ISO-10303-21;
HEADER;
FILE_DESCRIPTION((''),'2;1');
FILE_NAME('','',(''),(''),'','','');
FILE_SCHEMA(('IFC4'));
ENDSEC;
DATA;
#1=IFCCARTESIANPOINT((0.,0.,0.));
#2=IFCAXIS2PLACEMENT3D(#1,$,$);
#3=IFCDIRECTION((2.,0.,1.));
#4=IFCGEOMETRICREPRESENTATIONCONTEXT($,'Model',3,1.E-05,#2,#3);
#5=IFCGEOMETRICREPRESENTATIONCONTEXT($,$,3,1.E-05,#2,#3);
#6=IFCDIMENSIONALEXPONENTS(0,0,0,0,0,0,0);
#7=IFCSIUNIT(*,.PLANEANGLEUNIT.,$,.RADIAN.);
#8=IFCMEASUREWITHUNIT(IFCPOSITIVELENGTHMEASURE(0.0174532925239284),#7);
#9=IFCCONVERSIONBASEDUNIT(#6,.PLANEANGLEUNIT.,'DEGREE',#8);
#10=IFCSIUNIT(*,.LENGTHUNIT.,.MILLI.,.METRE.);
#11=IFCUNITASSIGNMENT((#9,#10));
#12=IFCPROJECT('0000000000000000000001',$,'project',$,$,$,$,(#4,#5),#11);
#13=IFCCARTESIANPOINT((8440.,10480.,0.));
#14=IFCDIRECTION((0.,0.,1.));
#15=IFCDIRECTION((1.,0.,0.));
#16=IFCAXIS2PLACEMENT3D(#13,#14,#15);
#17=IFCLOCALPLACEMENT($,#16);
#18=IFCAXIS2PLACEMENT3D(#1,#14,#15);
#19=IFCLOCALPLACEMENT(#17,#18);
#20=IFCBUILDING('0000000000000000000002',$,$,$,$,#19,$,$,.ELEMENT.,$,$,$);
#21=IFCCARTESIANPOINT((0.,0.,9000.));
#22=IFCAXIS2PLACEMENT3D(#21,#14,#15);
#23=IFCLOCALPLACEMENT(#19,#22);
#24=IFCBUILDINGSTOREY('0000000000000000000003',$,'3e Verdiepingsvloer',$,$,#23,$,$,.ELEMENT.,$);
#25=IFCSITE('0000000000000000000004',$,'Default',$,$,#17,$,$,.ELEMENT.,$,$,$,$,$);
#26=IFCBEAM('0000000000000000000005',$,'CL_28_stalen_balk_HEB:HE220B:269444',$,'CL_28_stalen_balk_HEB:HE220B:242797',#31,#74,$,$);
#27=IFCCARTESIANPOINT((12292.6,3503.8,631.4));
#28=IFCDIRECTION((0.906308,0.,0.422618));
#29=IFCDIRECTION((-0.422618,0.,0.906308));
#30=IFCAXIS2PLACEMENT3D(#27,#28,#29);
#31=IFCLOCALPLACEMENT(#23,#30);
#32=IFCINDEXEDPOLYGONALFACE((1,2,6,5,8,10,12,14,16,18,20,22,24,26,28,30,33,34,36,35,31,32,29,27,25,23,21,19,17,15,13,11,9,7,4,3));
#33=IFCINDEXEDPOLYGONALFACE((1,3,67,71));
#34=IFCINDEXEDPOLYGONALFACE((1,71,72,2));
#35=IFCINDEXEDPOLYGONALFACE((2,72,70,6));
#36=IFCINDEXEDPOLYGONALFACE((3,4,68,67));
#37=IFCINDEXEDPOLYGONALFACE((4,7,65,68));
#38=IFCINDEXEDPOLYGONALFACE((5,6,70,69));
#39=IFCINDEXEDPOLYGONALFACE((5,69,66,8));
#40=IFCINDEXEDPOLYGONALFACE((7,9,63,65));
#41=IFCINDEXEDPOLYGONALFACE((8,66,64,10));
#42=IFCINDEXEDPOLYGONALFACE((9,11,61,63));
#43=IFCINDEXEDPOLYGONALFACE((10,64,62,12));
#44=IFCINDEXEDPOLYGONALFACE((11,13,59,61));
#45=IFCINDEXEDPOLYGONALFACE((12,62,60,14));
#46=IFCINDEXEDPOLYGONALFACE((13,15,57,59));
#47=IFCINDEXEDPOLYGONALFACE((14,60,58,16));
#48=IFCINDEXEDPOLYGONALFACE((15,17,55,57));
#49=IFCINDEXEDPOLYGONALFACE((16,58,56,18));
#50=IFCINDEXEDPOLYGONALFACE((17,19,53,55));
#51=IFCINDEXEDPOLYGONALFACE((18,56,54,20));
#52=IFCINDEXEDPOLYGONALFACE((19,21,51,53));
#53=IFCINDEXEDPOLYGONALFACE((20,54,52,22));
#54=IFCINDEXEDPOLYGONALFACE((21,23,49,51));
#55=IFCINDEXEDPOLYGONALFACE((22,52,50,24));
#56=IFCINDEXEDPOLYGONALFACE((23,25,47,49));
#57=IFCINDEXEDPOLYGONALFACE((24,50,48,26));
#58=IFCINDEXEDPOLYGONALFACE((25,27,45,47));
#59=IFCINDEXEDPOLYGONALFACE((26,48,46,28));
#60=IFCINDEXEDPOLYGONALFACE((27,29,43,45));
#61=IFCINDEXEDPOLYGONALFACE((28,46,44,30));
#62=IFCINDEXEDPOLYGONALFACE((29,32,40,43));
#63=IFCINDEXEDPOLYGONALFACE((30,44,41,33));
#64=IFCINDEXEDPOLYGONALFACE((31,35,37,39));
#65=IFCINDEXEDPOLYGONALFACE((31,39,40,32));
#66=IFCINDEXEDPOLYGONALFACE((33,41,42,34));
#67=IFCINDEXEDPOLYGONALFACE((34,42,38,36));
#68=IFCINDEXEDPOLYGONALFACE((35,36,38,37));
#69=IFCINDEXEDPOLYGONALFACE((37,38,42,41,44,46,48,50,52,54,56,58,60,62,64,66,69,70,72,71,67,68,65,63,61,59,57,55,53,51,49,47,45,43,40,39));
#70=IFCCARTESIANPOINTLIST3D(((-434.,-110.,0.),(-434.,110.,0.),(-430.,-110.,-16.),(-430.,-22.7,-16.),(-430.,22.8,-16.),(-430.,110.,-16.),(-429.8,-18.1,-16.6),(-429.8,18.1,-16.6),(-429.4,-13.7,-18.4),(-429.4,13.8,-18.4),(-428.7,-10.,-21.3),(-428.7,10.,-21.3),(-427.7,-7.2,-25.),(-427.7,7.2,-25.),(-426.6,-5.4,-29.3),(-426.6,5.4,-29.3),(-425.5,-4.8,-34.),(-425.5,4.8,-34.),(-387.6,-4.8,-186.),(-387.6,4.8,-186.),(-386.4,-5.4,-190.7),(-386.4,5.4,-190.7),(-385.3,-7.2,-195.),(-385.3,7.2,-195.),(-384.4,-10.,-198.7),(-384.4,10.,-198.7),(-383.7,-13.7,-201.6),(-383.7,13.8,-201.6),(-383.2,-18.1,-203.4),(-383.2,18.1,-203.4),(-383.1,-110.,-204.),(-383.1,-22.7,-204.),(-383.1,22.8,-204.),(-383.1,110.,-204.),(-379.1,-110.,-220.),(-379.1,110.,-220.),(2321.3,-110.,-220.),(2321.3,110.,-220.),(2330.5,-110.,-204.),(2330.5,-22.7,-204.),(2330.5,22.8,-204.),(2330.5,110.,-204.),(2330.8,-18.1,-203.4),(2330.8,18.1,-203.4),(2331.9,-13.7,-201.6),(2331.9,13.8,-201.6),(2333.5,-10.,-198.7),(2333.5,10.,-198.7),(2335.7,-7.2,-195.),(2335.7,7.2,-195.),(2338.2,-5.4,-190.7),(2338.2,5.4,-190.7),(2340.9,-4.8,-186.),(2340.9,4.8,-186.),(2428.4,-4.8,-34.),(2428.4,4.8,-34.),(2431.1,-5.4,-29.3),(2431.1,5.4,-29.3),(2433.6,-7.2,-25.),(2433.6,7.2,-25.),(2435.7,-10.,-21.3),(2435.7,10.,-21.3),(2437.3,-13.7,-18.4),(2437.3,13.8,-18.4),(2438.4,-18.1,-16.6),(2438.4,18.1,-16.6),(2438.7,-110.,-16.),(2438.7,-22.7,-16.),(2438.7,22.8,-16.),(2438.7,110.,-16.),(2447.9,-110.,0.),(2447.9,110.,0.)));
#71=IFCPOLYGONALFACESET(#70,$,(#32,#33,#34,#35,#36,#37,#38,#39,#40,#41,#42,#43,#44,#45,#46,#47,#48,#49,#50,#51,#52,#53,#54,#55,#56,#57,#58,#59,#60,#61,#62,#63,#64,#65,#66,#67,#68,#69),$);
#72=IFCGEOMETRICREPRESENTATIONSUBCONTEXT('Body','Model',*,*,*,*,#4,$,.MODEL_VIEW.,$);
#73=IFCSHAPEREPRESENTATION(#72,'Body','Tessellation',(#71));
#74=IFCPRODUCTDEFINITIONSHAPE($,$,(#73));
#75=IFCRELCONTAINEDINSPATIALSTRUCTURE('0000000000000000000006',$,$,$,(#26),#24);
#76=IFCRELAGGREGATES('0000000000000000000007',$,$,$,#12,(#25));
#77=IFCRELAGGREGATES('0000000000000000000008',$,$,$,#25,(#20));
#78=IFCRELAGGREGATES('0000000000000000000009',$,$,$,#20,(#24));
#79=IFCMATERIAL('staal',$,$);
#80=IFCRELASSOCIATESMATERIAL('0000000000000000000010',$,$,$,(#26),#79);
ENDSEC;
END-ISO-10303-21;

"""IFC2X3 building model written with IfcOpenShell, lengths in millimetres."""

from ifc_helpers import new_model, entity, si_unit, converted_unit, direction, frame, frame_2d, origin, origin_with_axes, place, context, subcontext, project, spatial, i_section, extrude, clip, halfspace, material, element, save


model = new_model("IFC2X3")

# Units and contexts
model_context = context("Model", 3, precision=1e-05, world=origin(), true_north=direction((2.0, 0.0, 1.0)))
context_of_model = context(None, 3, precision=1e-05, world=origin(), true_north=direction((2.0, 0.0, 1.0)))
body_context = subcontext(model_context, "Body", "Model", "MODEL_VIEW")
ifc_project = project(units=[converted_unit("PLANEANGLEUNIT", "DEGREE", entity("IfcPositiveLengthMeasure", 0.0174532925239284), si_unit("PLANEANGLEUNIT", "RADIAN"), dimensions=[0, 0, 0, 0, 0, 0, 0]), si_unit("LENGTHUNIT", "METRE", prefix="MILLI")], contexts=[model_context, context_of_model])

# Site, building, storey
site_placement = place(None, frame((8440.0, 10480.0, 0.0), z_axis=(0.0, 0.0, 1.0), x_axis=(1.0, 0.0, 0.0)))
site = spatial("IfcSite", under=ifc_project, at=site_placement, Name="Default", CompositionType="ELEMENT")
building_placement = place(site_placement, origin_with_axes())
building = spatial("IfcBuilding", under=site, at=building_placement, CompositionType="ELEMENT")
storey_placement = place(building_placement, frame((0.0, 0.0, 9000.0), z_axis=(0.0, 0.0, 1.0), x_axis=(1.0, 0.0, 0.0)))
storey = spatial("IfcBuildingStorey", under=building, at=storey_placement, Name="3e Verdiepingsvloer", CompositionType="ELEMENT")

# Beam
ifc_material_1 = material(Name="staal")
beam_1_placement = place(storey_placement, frame((12292.6, 3503.8, 631.4), z_axis=(0.906308, 0.0, 0.422618), x_axis=(-0.422618, 0.0, 0.906308)))
element("IfcBeam", 1, at=beam_1_placement, inside=storey, material=ifc_material_1, Name="CL_28_stalen_balk_HEB:HE220B:269444", ObjectType="CL_28_stalen_balk_HEB:HE220B:242797", context=body_context, shape_type="Clipping", body=[
    clip(clip(extrude(i_section(OverallWidth=220.0, OverallDepth=220.0, WebThickness=9.5, FlangeThickness=16.0, FilletRadius=18.0, at=frame_2d((0.0, 0.0), x_axis=(0.0, 1.0))), frame((-434.0, 0.0, -110.0), z_axis=(1.0, 0.0, 0.0), x_axis=(0.0, 0.0, -1.0)), (0.0, 0.0, 1.0), 2881.9), halfspace(frame((-475.4, -2115.1, 166.1), z_axis=(-0.970296, 0.0, -0.241922), x_axis=(-0.241922, 0.0, 0.970296)), False)), halfspace(frame((2447.9, -2115.1, 0.0), z_axis=(0.86662, 0.0, -0.498969), x_axis=(0.498969, 0.0, 0.86662)), False)),
])

save(model, "model.ifc")
